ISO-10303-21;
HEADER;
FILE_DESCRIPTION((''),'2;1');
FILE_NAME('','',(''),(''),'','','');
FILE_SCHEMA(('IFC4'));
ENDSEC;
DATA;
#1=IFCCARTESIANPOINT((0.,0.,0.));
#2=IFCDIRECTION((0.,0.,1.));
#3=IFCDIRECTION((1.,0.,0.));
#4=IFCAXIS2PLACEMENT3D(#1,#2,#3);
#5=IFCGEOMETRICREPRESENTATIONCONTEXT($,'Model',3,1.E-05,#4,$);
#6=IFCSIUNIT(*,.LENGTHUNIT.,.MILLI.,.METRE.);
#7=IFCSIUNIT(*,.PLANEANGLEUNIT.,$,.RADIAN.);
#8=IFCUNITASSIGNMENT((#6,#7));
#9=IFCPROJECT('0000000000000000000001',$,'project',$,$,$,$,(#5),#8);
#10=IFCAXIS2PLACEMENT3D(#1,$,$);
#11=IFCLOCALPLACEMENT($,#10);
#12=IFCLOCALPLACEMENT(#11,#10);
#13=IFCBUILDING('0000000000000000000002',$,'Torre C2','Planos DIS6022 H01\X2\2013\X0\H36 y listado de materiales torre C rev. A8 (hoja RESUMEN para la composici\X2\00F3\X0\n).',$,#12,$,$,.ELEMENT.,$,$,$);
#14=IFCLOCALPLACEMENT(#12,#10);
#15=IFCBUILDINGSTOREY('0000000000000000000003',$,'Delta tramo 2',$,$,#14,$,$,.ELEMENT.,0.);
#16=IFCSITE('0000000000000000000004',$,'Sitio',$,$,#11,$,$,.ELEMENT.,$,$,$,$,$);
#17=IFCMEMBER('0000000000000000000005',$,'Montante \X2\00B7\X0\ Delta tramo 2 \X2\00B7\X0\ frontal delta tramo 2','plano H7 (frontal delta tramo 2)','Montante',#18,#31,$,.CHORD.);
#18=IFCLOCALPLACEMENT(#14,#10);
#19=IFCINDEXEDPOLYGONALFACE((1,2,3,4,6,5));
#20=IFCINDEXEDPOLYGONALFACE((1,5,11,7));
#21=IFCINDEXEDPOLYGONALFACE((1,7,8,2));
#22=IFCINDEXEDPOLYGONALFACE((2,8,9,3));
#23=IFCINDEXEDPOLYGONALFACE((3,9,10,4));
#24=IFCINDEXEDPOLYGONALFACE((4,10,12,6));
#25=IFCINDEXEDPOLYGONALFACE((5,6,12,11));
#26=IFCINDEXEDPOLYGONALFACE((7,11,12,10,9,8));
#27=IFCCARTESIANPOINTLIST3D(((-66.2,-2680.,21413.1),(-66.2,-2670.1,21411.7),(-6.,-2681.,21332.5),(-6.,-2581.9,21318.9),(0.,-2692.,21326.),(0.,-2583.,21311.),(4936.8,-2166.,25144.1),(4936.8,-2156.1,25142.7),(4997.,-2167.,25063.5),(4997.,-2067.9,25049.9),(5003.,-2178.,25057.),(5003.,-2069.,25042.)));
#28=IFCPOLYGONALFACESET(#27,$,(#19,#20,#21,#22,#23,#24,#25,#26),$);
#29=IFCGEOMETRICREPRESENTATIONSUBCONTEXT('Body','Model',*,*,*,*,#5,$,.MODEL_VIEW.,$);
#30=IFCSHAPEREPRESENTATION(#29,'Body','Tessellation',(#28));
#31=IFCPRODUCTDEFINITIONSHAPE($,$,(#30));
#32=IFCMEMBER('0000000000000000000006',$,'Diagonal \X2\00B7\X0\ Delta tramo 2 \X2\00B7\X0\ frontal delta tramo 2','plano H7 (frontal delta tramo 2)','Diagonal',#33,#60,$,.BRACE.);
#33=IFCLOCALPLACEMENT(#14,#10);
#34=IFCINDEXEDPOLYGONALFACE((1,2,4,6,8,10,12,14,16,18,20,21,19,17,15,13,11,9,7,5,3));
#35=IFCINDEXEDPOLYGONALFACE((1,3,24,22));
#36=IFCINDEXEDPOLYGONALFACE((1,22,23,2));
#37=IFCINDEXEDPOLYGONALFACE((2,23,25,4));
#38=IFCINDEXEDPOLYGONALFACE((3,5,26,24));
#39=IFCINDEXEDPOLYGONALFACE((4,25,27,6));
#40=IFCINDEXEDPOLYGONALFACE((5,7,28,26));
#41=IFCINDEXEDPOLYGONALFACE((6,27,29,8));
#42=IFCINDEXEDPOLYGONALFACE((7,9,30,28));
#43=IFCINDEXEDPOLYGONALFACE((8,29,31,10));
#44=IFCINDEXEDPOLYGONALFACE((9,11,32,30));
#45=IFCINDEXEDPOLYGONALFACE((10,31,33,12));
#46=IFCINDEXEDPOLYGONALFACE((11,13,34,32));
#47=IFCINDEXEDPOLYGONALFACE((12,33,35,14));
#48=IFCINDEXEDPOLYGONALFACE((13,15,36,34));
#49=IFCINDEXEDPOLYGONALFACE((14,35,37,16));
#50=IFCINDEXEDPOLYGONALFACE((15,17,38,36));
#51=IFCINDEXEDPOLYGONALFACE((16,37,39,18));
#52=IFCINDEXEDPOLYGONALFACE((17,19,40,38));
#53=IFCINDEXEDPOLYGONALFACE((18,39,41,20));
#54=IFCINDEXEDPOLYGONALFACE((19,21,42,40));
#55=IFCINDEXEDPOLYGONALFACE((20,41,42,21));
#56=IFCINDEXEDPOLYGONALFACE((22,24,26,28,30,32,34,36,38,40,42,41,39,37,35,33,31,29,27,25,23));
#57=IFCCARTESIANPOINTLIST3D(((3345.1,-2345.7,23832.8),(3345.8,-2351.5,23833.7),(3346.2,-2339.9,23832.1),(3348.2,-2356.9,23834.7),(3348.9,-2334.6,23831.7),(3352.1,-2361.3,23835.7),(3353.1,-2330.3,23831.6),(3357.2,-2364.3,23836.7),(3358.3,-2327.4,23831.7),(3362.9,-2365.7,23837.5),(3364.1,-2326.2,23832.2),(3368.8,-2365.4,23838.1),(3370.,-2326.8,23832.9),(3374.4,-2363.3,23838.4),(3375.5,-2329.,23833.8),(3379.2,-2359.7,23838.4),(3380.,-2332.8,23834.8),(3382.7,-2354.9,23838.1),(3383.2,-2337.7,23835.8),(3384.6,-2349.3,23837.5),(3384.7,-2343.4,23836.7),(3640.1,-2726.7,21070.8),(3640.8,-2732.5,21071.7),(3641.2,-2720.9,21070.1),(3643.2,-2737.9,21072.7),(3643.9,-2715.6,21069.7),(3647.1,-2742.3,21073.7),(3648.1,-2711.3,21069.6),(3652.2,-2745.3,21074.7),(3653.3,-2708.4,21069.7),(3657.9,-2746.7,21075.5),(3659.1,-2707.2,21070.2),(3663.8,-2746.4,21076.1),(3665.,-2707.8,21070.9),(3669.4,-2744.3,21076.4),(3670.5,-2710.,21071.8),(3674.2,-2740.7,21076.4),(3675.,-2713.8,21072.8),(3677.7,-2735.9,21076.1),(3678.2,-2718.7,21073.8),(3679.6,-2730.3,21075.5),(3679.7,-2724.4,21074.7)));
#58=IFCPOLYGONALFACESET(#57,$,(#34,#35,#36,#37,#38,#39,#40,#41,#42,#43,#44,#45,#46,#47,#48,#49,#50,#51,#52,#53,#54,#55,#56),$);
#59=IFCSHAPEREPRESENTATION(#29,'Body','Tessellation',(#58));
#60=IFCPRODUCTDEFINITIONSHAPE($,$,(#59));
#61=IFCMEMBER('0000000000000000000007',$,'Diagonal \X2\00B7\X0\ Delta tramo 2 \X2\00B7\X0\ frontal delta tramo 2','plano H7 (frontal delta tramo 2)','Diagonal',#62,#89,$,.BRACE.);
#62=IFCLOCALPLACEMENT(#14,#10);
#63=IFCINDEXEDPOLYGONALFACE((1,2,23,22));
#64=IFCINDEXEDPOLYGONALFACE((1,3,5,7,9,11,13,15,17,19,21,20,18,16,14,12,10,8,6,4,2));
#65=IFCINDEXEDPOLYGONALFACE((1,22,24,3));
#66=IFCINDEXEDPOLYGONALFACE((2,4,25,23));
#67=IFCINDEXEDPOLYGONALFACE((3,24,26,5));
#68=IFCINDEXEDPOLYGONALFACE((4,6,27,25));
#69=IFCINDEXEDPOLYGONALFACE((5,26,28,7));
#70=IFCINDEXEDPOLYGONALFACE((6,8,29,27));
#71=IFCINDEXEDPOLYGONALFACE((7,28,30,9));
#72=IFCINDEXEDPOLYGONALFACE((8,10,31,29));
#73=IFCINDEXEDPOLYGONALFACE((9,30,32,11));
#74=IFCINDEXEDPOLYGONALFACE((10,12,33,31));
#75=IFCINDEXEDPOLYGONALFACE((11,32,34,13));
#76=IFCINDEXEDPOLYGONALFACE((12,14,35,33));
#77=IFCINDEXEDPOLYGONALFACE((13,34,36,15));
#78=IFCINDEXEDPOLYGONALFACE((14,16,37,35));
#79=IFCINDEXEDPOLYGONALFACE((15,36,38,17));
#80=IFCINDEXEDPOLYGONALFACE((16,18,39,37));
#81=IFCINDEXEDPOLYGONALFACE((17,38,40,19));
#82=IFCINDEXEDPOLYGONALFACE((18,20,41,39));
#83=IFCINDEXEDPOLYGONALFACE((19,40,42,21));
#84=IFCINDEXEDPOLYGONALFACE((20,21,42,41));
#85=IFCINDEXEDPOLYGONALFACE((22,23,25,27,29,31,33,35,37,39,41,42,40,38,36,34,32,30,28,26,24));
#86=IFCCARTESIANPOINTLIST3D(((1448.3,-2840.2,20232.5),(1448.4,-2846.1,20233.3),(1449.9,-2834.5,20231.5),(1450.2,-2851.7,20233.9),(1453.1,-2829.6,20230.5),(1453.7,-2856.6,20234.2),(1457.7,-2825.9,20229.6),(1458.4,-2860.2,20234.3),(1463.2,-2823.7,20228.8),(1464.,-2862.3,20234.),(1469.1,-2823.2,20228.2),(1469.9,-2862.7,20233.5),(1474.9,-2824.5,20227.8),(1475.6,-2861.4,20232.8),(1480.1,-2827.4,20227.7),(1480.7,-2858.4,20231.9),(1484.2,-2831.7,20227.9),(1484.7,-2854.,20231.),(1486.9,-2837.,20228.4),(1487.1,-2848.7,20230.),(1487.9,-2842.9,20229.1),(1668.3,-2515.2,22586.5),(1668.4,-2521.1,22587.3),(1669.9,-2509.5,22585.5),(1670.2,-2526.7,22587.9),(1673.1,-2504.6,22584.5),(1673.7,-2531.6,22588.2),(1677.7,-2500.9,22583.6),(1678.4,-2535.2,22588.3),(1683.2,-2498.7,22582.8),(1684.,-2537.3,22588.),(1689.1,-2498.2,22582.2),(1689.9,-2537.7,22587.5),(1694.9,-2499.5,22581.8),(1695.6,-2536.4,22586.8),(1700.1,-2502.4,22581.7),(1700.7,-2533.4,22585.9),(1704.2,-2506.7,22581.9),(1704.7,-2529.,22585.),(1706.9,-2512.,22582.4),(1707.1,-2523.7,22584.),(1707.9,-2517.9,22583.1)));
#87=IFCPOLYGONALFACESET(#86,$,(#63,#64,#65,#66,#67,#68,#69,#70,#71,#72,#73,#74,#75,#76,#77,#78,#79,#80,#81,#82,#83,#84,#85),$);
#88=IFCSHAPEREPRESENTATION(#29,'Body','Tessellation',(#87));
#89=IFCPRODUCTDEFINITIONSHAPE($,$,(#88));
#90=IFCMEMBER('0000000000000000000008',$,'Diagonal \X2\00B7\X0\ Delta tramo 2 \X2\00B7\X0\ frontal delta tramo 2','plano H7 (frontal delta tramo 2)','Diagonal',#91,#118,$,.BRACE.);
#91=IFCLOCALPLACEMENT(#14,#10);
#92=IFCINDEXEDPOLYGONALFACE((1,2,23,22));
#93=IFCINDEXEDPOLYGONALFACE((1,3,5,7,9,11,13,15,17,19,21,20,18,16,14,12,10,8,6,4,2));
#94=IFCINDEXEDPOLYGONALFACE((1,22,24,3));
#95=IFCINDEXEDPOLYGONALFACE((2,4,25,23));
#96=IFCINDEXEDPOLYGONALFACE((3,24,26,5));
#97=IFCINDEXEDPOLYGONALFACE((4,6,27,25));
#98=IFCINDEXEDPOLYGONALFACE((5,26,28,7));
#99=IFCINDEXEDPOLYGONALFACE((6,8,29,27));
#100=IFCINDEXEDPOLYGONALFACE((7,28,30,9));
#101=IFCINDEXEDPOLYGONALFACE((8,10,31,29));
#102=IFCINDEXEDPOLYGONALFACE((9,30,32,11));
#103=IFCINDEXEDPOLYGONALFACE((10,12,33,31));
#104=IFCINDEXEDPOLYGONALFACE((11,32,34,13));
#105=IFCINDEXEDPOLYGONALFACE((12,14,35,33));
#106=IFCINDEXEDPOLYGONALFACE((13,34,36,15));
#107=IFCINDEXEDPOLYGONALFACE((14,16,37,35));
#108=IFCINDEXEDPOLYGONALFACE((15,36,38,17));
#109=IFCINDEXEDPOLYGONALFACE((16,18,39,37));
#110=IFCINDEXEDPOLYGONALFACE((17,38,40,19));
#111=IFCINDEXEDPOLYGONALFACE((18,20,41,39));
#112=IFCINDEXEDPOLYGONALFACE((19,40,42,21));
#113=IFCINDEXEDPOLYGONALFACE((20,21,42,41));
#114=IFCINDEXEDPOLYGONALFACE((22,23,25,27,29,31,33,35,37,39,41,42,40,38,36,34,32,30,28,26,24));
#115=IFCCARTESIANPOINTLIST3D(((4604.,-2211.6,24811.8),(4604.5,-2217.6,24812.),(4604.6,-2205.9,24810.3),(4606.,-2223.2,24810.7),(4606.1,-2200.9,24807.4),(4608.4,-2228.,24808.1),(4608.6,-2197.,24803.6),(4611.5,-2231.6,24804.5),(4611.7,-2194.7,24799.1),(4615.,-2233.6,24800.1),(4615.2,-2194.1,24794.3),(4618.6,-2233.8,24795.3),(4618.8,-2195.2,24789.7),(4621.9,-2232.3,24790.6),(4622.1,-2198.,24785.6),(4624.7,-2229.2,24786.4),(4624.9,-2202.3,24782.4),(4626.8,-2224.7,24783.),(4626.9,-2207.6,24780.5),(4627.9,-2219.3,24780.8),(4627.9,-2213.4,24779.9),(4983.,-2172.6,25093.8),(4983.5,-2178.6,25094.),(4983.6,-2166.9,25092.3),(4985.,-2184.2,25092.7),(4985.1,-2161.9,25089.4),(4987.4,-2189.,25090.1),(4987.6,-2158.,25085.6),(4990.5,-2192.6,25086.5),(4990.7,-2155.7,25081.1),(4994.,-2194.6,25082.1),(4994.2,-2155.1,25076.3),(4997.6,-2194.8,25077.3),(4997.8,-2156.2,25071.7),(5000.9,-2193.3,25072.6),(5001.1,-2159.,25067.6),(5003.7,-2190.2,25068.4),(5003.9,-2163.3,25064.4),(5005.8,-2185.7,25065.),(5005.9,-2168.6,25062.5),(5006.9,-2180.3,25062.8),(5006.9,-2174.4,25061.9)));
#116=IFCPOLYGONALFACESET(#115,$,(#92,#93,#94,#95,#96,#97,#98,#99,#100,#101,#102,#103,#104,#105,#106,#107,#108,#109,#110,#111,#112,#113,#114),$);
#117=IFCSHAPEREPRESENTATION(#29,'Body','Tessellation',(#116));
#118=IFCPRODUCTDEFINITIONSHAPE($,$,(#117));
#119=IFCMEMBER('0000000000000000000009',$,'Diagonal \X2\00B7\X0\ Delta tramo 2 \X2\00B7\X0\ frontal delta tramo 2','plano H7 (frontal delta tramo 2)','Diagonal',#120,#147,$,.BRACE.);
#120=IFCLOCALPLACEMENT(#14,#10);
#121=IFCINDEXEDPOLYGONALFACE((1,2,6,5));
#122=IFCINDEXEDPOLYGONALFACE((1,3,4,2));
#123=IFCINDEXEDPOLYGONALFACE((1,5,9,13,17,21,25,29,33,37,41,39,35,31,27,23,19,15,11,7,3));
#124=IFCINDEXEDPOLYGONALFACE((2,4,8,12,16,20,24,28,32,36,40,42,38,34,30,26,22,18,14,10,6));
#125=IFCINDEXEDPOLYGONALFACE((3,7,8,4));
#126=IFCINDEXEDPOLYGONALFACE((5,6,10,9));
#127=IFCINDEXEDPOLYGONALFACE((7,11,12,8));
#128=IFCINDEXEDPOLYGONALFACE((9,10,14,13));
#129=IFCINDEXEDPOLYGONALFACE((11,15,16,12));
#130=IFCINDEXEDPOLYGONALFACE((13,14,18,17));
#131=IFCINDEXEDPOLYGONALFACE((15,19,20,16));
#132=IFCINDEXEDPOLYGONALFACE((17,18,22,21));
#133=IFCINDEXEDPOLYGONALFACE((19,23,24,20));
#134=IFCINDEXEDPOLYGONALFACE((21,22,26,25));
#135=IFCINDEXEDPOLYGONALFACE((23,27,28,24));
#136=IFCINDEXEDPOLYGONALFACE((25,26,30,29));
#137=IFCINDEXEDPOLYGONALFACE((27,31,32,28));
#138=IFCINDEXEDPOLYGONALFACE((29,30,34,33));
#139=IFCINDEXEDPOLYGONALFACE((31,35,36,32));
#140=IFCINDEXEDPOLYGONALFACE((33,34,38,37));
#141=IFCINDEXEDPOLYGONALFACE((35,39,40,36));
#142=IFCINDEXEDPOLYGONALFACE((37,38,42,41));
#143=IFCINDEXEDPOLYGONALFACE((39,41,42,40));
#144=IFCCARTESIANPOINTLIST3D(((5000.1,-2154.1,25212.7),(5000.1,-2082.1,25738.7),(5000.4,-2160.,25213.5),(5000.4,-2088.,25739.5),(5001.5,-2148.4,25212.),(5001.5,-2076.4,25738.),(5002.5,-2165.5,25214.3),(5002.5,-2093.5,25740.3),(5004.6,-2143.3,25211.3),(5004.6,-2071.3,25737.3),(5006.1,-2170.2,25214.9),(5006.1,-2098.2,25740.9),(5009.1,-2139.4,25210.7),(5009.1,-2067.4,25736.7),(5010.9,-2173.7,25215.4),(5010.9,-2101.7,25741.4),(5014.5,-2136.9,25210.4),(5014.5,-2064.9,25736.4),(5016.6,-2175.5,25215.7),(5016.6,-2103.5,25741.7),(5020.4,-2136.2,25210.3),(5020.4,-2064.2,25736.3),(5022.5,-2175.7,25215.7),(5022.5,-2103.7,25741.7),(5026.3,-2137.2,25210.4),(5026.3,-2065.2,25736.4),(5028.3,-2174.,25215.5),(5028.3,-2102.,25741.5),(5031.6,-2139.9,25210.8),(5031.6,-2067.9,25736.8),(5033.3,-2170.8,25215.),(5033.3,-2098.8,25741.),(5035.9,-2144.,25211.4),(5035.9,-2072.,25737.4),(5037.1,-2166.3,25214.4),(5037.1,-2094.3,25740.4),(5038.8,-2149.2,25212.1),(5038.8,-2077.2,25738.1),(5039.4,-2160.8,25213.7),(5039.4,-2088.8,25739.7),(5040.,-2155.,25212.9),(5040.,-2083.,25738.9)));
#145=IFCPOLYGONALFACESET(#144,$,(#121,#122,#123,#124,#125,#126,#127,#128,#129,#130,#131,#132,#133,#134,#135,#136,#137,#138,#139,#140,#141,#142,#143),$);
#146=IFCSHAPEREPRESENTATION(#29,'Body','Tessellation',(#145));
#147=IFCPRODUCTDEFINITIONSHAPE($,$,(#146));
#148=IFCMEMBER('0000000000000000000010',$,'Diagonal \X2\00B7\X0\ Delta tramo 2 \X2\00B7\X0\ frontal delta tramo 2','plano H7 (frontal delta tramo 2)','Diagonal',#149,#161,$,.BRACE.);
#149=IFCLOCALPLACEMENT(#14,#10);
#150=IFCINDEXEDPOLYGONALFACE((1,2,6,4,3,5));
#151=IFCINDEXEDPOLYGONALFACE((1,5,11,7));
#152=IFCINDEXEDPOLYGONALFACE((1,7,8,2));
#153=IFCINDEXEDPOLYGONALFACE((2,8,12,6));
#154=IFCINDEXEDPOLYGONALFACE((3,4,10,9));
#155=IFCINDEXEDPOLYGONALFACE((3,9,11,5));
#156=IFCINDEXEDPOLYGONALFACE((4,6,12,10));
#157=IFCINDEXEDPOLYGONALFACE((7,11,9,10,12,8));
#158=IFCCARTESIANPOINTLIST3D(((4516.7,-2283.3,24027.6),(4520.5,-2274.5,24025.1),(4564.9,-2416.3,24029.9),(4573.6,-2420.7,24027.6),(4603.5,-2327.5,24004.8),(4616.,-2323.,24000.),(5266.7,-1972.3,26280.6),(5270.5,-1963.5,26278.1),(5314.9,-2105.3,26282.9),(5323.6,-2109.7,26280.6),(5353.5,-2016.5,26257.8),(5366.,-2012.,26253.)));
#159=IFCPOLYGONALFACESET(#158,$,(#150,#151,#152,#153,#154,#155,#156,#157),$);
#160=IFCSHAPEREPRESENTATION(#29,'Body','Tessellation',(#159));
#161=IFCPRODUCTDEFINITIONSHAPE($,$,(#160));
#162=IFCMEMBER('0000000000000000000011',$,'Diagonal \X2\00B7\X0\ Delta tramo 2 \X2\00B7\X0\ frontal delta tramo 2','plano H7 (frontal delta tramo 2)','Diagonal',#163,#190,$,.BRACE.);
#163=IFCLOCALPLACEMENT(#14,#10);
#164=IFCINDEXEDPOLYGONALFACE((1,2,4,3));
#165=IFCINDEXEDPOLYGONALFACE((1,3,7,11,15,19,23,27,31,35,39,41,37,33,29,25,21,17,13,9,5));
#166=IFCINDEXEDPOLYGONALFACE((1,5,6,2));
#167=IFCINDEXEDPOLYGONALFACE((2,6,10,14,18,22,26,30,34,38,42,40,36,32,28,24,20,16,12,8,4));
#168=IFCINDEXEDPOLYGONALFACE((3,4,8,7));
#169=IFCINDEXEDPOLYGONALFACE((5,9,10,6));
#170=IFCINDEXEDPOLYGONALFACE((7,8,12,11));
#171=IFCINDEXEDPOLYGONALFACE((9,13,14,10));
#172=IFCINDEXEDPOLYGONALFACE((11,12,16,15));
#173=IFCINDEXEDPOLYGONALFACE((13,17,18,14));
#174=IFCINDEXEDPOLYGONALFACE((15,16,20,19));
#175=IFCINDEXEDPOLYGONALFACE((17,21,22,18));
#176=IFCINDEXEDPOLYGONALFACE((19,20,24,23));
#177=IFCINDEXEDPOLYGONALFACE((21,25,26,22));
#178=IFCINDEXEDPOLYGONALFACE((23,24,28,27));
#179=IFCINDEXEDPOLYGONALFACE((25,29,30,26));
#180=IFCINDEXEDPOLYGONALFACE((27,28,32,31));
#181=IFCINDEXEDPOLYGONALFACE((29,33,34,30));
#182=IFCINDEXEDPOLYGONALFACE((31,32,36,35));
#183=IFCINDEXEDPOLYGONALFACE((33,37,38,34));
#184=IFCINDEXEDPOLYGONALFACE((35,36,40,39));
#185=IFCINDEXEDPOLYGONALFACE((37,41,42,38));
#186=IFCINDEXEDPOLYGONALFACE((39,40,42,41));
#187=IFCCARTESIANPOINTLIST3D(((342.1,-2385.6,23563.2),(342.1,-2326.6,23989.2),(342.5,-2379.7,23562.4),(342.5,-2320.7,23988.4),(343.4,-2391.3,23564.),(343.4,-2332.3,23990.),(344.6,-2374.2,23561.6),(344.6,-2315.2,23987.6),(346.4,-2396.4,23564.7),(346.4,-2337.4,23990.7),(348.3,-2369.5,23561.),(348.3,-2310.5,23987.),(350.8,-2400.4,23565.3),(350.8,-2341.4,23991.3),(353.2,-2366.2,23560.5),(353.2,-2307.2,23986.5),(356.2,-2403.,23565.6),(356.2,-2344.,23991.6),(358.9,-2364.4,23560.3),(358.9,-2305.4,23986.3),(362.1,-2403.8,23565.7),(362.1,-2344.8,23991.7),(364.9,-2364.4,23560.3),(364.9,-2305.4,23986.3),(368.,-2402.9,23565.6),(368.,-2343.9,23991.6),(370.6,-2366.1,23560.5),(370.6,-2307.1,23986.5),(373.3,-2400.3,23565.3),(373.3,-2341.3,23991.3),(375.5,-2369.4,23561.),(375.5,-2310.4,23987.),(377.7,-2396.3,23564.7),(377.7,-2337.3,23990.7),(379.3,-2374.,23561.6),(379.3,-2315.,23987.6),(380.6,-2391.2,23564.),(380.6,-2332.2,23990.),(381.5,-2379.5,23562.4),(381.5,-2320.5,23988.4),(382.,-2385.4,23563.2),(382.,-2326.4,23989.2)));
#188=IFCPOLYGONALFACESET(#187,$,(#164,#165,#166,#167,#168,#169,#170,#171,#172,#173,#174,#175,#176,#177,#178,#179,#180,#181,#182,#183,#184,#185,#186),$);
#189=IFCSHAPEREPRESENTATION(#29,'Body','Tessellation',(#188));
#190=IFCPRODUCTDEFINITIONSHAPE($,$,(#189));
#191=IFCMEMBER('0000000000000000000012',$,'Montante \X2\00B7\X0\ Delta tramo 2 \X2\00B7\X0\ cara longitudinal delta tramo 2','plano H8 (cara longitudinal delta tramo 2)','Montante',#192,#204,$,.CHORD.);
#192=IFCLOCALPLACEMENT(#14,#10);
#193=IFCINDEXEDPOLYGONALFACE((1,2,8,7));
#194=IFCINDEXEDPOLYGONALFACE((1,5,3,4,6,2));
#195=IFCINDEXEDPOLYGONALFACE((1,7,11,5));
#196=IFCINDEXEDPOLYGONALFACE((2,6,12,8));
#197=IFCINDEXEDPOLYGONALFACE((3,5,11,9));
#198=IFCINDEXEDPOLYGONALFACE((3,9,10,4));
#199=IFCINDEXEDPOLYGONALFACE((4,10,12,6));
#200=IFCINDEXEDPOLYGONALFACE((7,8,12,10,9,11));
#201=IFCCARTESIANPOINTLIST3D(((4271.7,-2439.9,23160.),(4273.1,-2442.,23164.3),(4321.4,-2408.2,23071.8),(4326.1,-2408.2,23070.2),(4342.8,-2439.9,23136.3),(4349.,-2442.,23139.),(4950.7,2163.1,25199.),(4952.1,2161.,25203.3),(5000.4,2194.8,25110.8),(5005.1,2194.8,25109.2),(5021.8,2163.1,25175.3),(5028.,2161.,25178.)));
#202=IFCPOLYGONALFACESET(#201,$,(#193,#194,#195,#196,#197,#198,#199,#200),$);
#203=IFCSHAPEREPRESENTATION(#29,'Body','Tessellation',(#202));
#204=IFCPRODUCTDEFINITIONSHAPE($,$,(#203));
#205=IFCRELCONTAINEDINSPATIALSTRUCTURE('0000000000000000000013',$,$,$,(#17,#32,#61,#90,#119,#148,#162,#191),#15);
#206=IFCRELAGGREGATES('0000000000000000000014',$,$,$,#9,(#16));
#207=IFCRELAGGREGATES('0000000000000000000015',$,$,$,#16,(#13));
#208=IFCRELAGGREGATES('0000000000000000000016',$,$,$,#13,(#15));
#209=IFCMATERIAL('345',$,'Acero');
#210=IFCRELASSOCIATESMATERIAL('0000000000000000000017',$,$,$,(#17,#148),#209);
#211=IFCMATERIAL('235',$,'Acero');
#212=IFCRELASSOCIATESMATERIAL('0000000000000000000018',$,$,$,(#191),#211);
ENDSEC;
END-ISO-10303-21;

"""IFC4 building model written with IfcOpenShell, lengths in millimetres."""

from ifc_helpers import new_model, si_unit, frame, frame_2d, origin, origin_with_axes, place, context, subcontext, project, spatial, circle, l_section, extrude, material, element, save


model = new_model("IFC4")

# Units and contexts
model_context = context("Model", 3, precision=1e-05, world=origin_with_axes())
body_context = subcontext(model_context, "Body", "Model", "MODEL_VIEW")
ifc_project = project(units=[si_unit("LENGTHUNIT", "METRE", prefix="MILLI"), si_unit("PLANEANGLEUNIT", "RADIAN")], contexts=[model_context])

# Site, building, storey
site_placement = place(None, origin())
site = spatial("IfcSite", under=ifc_project, at=site_placement, Name="Sitio", CompositionType="ELEMENT")
building_placement = place(site_placement, origin())
building = spatial("IfcBuilding", under=site, at=building_placement, Name="Torre C2", Description="Planos DIS6022 H01–H36 y listado de materiales torre C rev. A8 (hoja RESUMEN para la composición).", CompositionType="ELEMENT")
storey_placement = place(building_placement, origin())
storey = spatial("IfcBuildingStorey", under=building, at=storey_placement, Name="Delta tramo 2", CompositionType="ELEMENT", Elevation=0.0)

# Members
ifc_material_1 = material(Name="345", Category="Acero")
member_1_placement = place(storey_placement, frame((5003.0, -2178.0, 25057.0), z_axis=(-0.798926, -0.08208, -0.595801), x_axis=(-0.601429, 0.109034, 0.791451)))
element("IfcMember", 1, at=member_1_placement, inside=storey, material=ifc_material_1, Name="Montante · Delta tramo 2 · frontal delta tramo 2", Description="plano H7 (frontal delta tramo 2)", ObjectType="Montante", PredefinedType="CHORD", context=body_context, shape_type="SweptSolid", body=[
    extrude(l_section(Depth=110.0, Width=110.0, Thickness=10.0, at=frame_2d((55.0, 55.0))), None, (0.0, 0.0, 1.0), 6262.2),
])
member_2_placement = place(storey_placement, frame((3365.0, -2346.0, 23835.0), z_axis=(0.105217, -0.135891, -0.985121), x_axis=(-0.804373, 0.570852, -0.164658)))
element("IfcMember", 2, at=member_2_placement, inside=storey, Name="Diagonal · Delta tramo 2 · frontal delta tramo 2", Description="plano H7 (frontal delta tramo 2)", ObjectType="Diagonal", PredefinedType="BRACE", context=body_context, shape_type="SweptSolid", body=[
    extrude(circle(Radius=20.0), None, (0.0, 0.0, 1.0), 2803.7),
])
member_3_placement = place(storey_placement, frame((1688.0, -2518.0, 22585.0), z_axis=(-0.092186, -0.136183, -0.986385), x_axis=(-0.515108, 0.854278, -0.069803)))
element("IfcMember", 3, at=member_3_placement, inside=storey, Name="Diagonal · Delta tramo 2 · frontal delta tramo 2", Description="plano H7 (frontal delta tramo 2)", ObjectType="Diagonal", PredefinedType="BRACE", context=body_context, shape_type="SweptSolid", body=[
    extrude(circle(Radius=20.0), None, (0.0, 0.0, 1.0), 2386.5),
])
member_4_placement = place(storey_placement, frame((4995.0, -2175.0, 25078.0), z_axis=(-0.79956, -0.082277, -0.594923), x_axis=(-0.493108, 0.655414, 0.572081)))
element("IfcMember", 4, at=member_4_placement, inside=storey, Name="Diagonal · Delta tramo 2 · frontal delta tramo 2", Description="plano H7 (frontal delta tramo 2)", ObjectType="Diagonal", PredefinedType="BRACE", context=body_context, shape_type="SweptSolid", body=[
    extrude(circle(Radius=20.0), None, (0.0, 0.0, 1.0), 474.0),
])
member_5_placement = place(storey_placement, frame((5020.0, -2156.0, 25213.0), z_axis=(0.0, 0.135618, 0.990761), x_axis=(-0.922505, 0.382419, -0.052346)))
element("IfcMember", 5, at=member_5_placement, inside=storey, Name="Diagonal · Delta tramo 2 · frontal delta tramo 2", Description="plano H7 (frontal delta tramo 2)", ObjectType="Diagonal", PredefinedType="BRACE", context=body_context, shape_type="SweptSolid", body=[
    extrude(circle(Radius=20.0), None, (0.0, 0.0, 1.0), 530.9),
])
member_6_placement = place(storey_placement, frame((4616.0, -2323.0, 24000.0), z_axis=(0.313174, 0.129863, 0.940775), x_axis=(-0.867893, 0.441341, 0.22799)))
element("IfcMember", 6, at=member_6_placement, inside=storey, material=ifc_material_1, Name="Diagonal · Delta tramo 2 · frontal delta tramo 2", Description="plano H7 (frontal delta tramo 2)", ObjectType="Diagonal", PredefinedType="BRACE", context=body_context, shape_type="SweptSolid", body=[
    extrude(l_section(Depth=110.0, Width=110.0, Thickness=10.0, at=frame_2d((55.0, 55.0))), None, (0.0, 0.0, 1.0), 2394.8),
])
for number, where, z_axis, x_axis, name in (
    (7, (362.0, -2384.0, 23563.0), (0.0, 0.137188, 0.990545), (-0.153379, 0.978824, -0.135565), "Diagonal · Delta tramo 2 · frontal delta tramo 2"),
):
    element("IfcMember", number, at=place(storey_placement, frame(where, z_axis=z_axis, x_axis=x_axis)), inside=storey, Name=name, Description="plano H7 (frontal delta tramo 2)", ObjectType="Diagonal", PredefinedType="BRACE", context=body_context, shape_type="SweptSolid", body=[
        extrude(circle(Radius=20.0), None, (0.0, 0.0, 1.0), 430.1),
    ])
ifc_material_2 = material(Name="235", Category="Acero")
member_7_placement = place(storey_placement, frame((4349.0, -2442.0, 23139.0), z_axis=(0.133662, 0.906106, 0.40138), x_axis=(-0.286283, 0.42305, -0.859692)))
element("IfcMember", 8, at=member_7_placement, inside=storey, material=ifc_material_2, Name="Montante · Delta tramo 2 · cara longitudinal delta tramo 2", Description="plano H8 (cara longitudinal delta tramo 2)", ObjectType="Montante", PredefinedType="CHORD", context=body_context, shape_type="SweptSolid", body=[
    extrude(l_section(Depth=80.0, Width=80.0, Thickness=5.0, at=frame_2d((40.0, 40.0))), None, (0.0, 0.0, 1.0), 5080.0),
])

save(model, "model.ifc")
